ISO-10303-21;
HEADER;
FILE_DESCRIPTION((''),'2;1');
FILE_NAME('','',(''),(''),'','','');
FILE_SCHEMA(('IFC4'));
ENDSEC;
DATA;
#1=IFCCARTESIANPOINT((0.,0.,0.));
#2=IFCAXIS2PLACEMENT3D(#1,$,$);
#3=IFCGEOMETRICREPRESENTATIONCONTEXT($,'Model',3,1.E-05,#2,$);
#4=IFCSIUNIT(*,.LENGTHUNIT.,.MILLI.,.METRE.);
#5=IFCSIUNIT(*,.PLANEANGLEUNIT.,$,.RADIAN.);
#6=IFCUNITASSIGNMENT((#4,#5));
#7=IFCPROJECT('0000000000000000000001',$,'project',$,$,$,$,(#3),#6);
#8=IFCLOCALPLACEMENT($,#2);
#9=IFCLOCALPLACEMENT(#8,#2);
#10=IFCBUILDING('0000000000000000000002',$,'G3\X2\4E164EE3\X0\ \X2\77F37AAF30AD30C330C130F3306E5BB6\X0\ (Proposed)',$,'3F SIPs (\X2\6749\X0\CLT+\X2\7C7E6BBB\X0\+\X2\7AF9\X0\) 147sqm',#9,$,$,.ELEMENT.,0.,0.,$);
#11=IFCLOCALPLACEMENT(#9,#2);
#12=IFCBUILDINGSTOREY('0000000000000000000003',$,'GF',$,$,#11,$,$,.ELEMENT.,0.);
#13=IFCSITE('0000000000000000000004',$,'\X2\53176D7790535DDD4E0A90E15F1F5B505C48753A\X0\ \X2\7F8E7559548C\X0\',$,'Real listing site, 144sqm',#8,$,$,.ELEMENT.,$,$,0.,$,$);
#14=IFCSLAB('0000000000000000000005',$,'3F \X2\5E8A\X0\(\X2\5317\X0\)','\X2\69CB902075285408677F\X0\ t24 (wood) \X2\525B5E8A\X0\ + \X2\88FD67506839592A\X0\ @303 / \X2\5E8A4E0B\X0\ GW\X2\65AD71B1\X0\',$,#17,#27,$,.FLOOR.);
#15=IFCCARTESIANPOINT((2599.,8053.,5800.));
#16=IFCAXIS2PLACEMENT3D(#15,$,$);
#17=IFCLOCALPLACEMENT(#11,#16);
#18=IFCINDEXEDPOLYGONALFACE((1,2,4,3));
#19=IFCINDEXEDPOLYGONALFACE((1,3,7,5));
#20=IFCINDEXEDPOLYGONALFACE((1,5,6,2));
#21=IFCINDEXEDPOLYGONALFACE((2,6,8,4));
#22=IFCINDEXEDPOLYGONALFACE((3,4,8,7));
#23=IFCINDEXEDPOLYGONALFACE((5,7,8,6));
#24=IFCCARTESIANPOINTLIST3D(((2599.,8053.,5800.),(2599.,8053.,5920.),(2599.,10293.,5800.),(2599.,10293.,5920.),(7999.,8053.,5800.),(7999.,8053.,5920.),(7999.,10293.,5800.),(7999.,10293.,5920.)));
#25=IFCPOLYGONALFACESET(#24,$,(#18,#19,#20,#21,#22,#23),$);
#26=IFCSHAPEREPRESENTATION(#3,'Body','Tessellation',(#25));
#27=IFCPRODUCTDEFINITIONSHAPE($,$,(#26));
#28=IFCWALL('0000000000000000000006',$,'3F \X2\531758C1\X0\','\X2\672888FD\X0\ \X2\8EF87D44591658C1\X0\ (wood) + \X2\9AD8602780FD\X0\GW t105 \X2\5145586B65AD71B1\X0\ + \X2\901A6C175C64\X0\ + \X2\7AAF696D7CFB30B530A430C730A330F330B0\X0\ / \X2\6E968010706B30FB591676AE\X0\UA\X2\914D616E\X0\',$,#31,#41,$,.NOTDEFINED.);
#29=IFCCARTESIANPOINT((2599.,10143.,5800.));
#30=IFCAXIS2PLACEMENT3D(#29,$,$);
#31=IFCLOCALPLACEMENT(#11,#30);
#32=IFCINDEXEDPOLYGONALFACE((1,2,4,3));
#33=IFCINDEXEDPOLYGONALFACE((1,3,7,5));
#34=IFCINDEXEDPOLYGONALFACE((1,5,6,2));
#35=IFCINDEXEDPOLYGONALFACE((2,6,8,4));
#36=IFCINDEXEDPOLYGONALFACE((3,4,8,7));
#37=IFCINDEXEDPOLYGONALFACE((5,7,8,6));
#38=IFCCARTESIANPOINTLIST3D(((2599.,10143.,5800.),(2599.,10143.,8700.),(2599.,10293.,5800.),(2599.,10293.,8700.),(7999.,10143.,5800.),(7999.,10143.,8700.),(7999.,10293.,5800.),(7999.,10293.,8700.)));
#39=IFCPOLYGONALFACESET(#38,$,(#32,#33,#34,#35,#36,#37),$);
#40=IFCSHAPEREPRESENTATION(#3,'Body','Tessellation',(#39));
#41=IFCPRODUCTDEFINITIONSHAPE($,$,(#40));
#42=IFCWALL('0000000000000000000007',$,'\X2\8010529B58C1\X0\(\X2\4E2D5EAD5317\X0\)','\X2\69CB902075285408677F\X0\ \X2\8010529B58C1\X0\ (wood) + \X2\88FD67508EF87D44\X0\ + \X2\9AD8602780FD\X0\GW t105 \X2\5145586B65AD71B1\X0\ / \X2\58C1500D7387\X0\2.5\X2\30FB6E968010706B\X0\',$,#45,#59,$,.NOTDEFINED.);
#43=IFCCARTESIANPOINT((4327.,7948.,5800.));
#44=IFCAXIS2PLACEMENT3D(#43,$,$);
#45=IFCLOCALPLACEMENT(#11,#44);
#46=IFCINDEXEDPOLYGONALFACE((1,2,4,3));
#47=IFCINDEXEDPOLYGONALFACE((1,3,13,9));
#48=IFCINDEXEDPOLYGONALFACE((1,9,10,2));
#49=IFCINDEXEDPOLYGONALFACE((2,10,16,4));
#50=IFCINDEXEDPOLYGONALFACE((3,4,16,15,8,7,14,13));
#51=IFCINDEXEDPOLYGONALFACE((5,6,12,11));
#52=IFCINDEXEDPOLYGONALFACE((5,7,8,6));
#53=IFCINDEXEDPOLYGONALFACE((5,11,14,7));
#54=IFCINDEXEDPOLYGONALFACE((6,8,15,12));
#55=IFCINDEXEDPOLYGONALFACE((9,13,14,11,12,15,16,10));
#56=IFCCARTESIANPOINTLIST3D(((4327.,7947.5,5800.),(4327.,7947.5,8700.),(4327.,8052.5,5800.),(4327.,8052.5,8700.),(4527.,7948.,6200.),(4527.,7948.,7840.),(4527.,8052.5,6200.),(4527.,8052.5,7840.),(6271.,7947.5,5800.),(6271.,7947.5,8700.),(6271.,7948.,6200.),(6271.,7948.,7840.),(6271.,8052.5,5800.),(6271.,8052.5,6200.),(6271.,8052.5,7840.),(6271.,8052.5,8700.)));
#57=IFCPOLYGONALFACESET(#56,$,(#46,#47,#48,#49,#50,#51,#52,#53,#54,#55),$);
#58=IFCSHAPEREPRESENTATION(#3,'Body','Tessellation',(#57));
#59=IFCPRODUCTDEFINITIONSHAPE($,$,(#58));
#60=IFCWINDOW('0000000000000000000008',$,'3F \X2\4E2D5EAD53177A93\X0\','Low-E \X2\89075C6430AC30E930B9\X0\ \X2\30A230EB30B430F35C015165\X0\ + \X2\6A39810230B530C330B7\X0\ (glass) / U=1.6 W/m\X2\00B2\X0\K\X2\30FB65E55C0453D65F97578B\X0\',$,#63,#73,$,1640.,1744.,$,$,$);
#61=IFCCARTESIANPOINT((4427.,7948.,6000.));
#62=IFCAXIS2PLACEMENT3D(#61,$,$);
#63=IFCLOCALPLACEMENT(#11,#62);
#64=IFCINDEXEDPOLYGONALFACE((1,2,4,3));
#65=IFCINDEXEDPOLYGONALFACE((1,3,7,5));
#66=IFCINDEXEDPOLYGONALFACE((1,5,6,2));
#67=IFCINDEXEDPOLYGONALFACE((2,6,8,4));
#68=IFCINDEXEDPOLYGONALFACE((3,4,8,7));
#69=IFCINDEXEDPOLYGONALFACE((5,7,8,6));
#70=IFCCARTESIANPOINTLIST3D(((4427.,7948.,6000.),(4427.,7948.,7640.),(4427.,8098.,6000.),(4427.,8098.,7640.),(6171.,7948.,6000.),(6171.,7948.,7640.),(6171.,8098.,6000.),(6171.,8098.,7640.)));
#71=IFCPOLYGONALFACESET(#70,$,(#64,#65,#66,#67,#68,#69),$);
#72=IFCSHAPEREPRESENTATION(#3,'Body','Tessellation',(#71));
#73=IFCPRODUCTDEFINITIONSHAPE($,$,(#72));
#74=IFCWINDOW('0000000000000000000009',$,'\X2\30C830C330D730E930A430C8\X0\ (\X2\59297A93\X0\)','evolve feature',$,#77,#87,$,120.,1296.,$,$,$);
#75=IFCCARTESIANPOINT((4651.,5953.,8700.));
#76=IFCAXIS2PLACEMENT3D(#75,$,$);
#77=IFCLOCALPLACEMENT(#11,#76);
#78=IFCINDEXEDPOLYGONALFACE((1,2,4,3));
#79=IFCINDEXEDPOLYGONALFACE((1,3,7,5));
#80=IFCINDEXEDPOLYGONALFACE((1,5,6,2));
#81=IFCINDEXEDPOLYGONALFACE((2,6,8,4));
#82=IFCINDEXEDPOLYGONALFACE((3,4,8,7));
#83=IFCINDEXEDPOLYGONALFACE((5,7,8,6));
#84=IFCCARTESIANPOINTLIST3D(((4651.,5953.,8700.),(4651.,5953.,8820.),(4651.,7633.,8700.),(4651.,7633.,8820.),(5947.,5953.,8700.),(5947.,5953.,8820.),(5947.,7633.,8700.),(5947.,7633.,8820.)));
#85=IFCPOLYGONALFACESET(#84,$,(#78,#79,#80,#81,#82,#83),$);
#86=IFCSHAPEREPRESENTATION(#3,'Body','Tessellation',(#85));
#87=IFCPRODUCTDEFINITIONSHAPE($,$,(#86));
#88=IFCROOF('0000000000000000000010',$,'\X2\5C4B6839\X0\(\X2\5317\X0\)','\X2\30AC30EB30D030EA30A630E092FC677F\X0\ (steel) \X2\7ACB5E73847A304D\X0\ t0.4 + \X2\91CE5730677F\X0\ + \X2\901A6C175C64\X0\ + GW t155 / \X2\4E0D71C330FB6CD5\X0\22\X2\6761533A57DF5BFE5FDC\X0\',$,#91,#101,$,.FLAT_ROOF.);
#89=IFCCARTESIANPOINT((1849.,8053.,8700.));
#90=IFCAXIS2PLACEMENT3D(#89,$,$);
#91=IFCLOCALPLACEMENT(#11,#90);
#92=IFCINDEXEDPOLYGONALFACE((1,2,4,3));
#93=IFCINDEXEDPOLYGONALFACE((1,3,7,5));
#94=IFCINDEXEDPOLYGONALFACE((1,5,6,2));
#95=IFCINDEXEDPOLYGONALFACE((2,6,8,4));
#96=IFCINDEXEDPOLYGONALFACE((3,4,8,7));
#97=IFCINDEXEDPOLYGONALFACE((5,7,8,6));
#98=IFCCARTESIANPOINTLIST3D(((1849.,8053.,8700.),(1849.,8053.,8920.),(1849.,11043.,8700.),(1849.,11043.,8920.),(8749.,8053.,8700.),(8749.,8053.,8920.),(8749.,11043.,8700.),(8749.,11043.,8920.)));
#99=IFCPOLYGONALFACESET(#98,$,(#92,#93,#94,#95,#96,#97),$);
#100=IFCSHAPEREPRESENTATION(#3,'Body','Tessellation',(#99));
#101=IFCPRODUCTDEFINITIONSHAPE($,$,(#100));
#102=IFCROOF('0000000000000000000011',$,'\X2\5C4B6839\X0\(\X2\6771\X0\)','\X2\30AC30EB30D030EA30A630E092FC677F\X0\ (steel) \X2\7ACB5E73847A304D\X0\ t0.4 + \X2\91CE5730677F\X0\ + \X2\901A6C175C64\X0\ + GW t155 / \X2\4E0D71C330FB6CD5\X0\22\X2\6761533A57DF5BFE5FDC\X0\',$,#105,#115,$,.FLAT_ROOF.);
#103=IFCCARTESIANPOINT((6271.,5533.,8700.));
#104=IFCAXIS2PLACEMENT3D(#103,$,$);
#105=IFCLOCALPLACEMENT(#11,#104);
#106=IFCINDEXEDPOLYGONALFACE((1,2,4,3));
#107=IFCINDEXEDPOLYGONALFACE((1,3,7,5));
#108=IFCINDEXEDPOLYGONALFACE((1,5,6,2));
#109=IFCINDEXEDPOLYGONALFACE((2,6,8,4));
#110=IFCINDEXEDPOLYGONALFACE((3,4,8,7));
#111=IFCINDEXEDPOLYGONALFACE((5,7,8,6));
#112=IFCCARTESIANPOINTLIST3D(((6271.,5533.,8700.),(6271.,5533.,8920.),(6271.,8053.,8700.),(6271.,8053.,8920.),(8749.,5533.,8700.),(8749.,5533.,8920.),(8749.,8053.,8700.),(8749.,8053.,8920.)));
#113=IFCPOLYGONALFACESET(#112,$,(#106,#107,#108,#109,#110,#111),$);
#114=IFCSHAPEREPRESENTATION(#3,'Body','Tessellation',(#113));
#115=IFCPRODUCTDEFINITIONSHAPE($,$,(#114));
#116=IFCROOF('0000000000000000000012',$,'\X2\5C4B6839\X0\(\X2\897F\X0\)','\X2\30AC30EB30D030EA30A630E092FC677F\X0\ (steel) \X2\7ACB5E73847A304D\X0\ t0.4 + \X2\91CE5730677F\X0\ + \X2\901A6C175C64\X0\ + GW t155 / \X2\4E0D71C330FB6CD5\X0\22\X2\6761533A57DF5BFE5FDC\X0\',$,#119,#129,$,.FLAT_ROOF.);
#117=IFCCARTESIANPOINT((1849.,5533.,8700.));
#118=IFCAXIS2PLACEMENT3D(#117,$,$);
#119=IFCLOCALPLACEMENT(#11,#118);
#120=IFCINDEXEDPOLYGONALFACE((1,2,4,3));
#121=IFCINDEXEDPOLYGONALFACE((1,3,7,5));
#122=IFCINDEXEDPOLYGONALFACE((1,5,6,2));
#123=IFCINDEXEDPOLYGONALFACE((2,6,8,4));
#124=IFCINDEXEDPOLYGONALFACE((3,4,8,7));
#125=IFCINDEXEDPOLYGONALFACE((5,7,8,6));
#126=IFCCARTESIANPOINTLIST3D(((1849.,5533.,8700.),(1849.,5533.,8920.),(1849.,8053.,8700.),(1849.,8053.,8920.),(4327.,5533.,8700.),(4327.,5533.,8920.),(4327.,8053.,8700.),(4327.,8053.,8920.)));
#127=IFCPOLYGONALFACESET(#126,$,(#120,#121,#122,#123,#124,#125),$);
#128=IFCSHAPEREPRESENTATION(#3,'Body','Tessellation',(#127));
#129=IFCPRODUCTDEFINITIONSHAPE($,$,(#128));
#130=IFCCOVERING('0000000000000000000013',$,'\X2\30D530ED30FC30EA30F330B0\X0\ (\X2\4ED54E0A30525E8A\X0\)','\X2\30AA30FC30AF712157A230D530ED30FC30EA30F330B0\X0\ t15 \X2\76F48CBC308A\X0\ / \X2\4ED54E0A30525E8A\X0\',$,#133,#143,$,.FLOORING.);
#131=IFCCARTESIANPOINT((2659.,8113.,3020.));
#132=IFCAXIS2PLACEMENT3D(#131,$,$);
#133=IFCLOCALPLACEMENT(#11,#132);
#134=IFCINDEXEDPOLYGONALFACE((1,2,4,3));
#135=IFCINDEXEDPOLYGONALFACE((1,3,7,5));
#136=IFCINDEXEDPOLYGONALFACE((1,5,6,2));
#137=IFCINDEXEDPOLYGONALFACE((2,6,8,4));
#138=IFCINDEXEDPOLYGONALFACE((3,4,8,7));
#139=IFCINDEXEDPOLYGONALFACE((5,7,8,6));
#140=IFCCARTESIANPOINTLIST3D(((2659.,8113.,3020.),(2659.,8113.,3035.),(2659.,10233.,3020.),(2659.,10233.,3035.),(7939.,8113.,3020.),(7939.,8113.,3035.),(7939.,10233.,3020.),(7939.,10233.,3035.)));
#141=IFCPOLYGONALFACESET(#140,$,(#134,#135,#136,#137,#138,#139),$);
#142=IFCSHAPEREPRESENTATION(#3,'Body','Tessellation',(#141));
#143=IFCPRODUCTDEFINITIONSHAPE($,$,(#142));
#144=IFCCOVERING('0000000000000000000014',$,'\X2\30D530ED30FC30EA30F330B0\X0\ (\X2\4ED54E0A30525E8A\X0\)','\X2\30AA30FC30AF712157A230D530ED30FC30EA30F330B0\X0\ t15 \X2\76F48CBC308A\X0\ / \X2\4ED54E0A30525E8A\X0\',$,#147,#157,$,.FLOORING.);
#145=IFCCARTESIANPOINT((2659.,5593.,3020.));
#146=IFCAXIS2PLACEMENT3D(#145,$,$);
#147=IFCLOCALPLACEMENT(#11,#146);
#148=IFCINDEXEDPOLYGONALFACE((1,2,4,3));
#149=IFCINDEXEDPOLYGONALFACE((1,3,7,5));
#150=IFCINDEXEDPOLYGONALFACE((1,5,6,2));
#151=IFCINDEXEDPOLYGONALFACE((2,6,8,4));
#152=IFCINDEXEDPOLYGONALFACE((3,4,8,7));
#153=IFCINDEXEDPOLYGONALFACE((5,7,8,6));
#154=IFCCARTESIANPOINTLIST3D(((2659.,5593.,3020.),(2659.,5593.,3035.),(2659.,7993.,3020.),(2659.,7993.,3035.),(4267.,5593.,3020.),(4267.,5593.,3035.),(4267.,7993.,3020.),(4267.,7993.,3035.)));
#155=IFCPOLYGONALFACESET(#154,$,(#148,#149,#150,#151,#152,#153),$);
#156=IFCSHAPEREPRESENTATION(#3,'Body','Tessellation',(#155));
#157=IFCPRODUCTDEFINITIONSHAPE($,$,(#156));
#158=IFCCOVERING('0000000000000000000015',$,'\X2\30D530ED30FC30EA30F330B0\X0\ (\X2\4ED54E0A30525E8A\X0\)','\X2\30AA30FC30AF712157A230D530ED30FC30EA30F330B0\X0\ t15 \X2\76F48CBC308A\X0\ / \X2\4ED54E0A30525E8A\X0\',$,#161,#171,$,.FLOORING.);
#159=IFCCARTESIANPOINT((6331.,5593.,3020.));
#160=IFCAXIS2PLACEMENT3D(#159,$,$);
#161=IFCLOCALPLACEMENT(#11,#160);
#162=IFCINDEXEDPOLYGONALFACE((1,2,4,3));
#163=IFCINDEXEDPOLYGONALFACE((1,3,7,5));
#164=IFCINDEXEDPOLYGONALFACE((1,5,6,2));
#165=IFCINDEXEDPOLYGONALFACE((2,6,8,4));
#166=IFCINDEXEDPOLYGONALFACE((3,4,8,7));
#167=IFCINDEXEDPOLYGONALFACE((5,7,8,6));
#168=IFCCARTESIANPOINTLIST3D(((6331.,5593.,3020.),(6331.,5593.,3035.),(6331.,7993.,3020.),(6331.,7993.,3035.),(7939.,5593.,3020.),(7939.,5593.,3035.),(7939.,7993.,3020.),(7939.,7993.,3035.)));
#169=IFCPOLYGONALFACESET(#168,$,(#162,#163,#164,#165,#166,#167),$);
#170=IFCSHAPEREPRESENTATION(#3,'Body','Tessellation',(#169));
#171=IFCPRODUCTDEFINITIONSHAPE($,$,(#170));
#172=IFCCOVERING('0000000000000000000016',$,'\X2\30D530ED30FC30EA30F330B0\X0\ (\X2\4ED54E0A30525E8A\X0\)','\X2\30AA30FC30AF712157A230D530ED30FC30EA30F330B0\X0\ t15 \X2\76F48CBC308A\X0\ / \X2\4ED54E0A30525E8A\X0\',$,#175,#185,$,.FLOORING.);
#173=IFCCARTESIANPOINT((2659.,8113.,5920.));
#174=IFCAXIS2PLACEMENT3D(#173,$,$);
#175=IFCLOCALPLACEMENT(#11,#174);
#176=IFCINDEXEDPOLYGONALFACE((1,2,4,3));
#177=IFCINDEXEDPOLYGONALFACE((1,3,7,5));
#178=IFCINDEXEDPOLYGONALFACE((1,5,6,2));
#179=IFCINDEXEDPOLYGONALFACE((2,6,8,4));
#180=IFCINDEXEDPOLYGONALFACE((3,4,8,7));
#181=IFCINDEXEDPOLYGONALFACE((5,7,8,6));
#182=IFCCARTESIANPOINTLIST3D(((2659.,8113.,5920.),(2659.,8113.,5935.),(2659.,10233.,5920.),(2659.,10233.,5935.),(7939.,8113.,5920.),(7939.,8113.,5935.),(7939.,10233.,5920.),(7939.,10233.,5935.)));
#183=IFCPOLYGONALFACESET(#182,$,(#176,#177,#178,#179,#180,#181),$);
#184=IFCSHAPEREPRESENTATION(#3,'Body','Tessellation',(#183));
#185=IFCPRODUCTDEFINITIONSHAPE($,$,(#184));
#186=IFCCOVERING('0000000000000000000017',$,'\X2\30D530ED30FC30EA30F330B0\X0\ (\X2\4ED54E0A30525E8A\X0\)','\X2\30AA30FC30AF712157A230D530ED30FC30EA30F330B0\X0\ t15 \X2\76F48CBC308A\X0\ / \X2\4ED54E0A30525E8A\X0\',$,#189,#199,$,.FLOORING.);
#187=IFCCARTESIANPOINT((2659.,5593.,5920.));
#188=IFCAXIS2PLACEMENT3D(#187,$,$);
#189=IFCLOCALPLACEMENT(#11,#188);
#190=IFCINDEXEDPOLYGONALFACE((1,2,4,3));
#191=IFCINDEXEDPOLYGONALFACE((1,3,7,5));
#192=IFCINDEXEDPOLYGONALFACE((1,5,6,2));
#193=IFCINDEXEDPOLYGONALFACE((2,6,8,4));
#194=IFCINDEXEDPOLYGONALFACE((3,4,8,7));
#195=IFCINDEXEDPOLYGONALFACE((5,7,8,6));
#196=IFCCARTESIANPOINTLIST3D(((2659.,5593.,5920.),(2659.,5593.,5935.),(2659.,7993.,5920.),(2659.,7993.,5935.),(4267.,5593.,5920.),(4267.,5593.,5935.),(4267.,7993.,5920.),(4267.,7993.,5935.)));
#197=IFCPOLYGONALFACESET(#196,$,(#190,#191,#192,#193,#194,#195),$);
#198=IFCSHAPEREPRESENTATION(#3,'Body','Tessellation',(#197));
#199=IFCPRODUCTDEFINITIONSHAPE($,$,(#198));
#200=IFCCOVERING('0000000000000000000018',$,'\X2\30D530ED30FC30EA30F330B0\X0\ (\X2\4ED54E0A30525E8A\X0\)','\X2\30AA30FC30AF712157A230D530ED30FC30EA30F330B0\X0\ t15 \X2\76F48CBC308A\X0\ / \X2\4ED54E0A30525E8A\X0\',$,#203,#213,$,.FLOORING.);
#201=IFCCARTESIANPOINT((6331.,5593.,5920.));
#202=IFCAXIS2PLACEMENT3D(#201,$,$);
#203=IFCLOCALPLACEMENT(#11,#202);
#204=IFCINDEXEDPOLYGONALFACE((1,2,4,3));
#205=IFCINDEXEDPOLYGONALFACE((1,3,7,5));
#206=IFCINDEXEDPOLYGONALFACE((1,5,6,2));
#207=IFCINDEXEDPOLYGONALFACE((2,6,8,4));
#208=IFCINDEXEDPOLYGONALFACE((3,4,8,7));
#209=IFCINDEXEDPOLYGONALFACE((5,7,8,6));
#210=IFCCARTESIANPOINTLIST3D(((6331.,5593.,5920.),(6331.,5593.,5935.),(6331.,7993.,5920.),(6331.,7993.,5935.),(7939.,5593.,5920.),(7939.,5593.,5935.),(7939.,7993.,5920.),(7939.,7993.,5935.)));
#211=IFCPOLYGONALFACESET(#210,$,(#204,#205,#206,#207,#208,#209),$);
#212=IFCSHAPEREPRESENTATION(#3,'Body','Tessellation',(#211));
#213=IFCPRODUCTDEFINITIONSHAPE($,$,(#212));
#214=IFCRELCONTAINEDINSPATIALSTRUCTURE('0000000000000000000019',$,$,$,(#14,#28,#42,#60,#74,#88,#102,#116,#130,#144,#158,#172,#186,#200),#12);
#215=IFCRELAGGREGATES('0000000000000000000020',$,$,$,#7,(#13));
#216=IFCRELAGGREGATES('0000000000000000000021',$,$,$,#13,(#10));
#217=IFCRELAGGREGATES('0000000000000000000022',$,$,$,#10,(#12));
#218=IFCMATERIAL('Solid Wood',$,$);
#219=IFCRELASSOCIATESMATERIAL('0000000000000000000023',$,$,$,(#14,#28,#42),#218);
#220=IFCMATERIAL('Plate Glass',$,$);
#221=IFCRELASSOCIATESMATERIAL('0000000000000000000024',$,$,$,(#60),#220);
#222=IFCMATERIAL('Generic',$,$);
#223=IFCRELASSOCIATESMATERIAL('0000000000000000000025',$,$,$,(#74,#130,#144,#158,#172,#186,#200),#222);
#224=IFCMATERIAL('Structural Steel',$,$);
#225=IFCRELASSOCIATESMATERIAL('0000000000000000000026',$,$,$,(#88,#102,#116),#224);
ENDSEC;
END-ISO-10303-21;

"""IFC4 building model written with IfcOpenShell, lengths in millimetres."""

from ifc_helpers import new_model, si_unit, frame, frame_2d, origin, place, context, project, spatial, rectangle, extrude, material, element, fill, save


model = new_model("IFC4")

# Units and contexts
model_context = context("Model", 3, precision=1e-05, world=origin())
ifc_project = project(units=[si_unit("LENGTHUNIT", "METRE", prefix="MILLI"), si_unit("PLANEANGLEUNIT", "RADIAN")], contexts=[model_context])

# Site, building, storey
site_placement = place(None, origin())
site = spatial("IfcSite", under=ifc_project, at=site_placement, Name="北海道川上郡弟子屈町 美留和", ObjectType="Real listing site, 144sqm", CompositionType="ELEMENT", RefElevation=0.0)
building_placement = place(site_placement, origin())
building = spatial("IfcBuilding", under=site, at=building_placement, Name="G3世代 石窯キッチンの家 (Proposed)", ObjectType="3F SIPs (杉CLT+籾殻+竹) 147sqm", CompositionType="ELEMENT", ElevationOfRefHeight=0.0, ElevationOfTerrain=0.0)
storey_placement = place(building_placement, origin())
storey = spatial("IfcBuildingStorey", under=building, at=storey_placement, Name="GF", CompositionType="ELEMENT", Elevation=0.0)

# Slab
ifc_material_1 = material(Name="Solid Wood")
slab_placement = place(storey_placement, frame((2599.0, 8053.0, 5800.0)))
element("IfcSlab", 1, at=slab_placement, inside=storey, material=ifc_material_1, Name="3F 床(北)", Description="構造用合板 t24 (wood) 剛床 + 製材根太 @303 / 床下 GW断熱", PredefinedType="FLOOR", context=model_context, shape_type="SweptSolid", body=[
    extrude(rectangle(XDim=5400.0, YDim=2240.0, at=frame_2d((2700.0, 1120.0))), frame((2599.0, 8053.0, 5800.0)), (0.0, 0.0, 1.0), 120.0),
])

# Wall
wall_1_placement = place(storey_placement, frame((2599.0, 10143.0, 5800.0)))
element("IfcWall", 2, at=wall_1_placement, inside=storey, material=ifc_material_1, Name="3F 北壁", Description="木製 軸組外壁 (wood) + 高性能GW t105 充填断熱 + 通気層 + 窯業系サイディング / 準耐火・外皮UA配慮", PredefinedType="NOTDEFINED", context=model_context, shape_type="SweptSolid", body=[
    extrude(rectangle(XDim=5400.0, YDim=150.0, at=frame_2d((2700.0, 75.0))), frame((2599.0, 10143.0, 5800.0)), (0.0, 0.0, 1.0), 2900.0),
])

# Wall, opening, window
wall_2_placement = place(storey_placement, frame((4327.0, 7948.0, 5800.0)))
wall_2 = element("IfcWall", 3, at=wall_2_placement, inside=storey, material=ifc_material_1, Name="耐力壁(中庭北)", Description="構造用合板 耐力壁 (wood) + 製材軸組 + 高性能GW t105 充填断熱 / 壁倍率2.5・準耐火", PredefinedType="NOTDEFINED", context=model_context, shape_type="SweptSolid", body=[
    extrude(rectangle(XDim=1944.0, YDim=105.0, at=frame_2d((972.0, 52.0))), frame((4327.0, 7948.0, 5800.0)), (0.0, 0.0, 1.0), 2900.0),
])
opening_placement = place(storey_placement, frame((4427.0, 7948.0, 6000.0)))
opening = element("IfcOpeningElement", 4, at=opening_placement, cuts=wall_2, PredefinedType="NOTDEFINED", context=model_context, shape_type="SweptSolid", body=[
    extrude(rectangle(XDim=1744.0, YDim=150.0, at=frame_2d((872.0, 75.0))), frame((4427.0, 7948.0, 6000.0)), (0.0, 0.0, 1.0), 1640.0),
])
ifc_material_2 = material(Name="Plate Glass")
window_1_placement = place(storey_placement, frame((4427.0, 7948.0, 6000.0)))
window_1 = element("IfcWindow", 5, at=window_1_placement, inside=storey, material=ifc_material_2, Name="3F 中庭北窓", Description="Low-E 複層ガラス アルゴン封入 + 樹脂サッシ (glass) / U=1.6 W/m²K・日射取得型", OverallHeight=1640.0, OverallWidth=1744.0, context=model_context, shape_type="SweptSolid", body=[
    extrude(rectangle(XDim=1744.0, YDim=150.0, at=frame_2d((872.0, 75.0))), frame((4427.0, 7948.0, 6000.0)), (0.0, 0.0, 1.0), 1640.0),
])
fill(opening, window_1)

# Window
ifc_material_3 = material(Name="Generic")
window_2_placement = place(storey_placement, frame((4651.0, 5953.0, 8700.0)))
element("IfcWindow", 6, at=window_2_placement, inside=storey, material=ifc_material_3, Name="トップライト (天窓)", Description="evolve feature", OverallHeight=120.0, OverallWidth=1296.0, context=model_context, shape_type="SweptSolid", body=[
    extrude(rectangle(XDim=1296.0, YDim=1680.0, at=frame_2d((648.0, 840.0))), frame((4651.0, 5953.0, 8700.0)), (0.0, 0.0, 1.0), 120.0),
])

# Roofs
ifc_material_4 = material(Name="Structural Steel")
roof_1_placement = place(storey_placement, frame((1849.0, 8053.0, 8700.0)))
element("IfcRoof", 7, at=roof_1_placement, inside=storey, material=ifc_material_4, Name="屋根(北)", Description="ガルバリウム鋼板 (steel) 立平葺き t0.4 + 野地板 + 通気層 + GW t155 / 不燃・法22条区域対応", PredefinedType="FLAT_ROOF", context=model_context, shape_type="SweptSolid", body=[
    extrude(rectangle(XDim=6900.0, YDim=2990.0, at=frame_2d((3450.0, 1495.0))), frame((1849.0, 8053.0, 8700.0)), (0.0, 0.0, 1.0), 220.0),
])
roof_2_placement = place(storey_placement, frame((6271.0, 5533.0, 8700.0)))
element("IfcRoof", 8, at=roof_2_placement, inside=storey, material=ifc_material_4, Name="屋根(東)", Description="ガルバリウム鋼板 (steel) 立平葺き t0.4 + 野地板 + 通気層 + GW t155 / 不燃・法22条区域対応", PredefinedType="FLAT_ROOF", context=model_context, shape_type="SweptSolid", body=[
    extrude(rectangle(XDim=2478.0, YDim=2520.0, at=frame_2d((1239.0, 1260.0))), frame((6271.0, 5533.0, 8700.0)), (0.0, 0.0, 1.0), 220.0),
])
roof_3_placement = place(storey_placement, frame((1849.0, 5533.0, 8700.0)))
element("IfcRoof", 9, at=roof_3_placement, inside=storey, material=ifc_material_4, Name="屋根(西)", Description="ガルバリウム鋼板 (steel) 立平葺き t0.4 + 野地板 + 通気層 + GW t155 / 不燃・法22条区域対応", PredefinedType="FLAT_ROOF", context=model_context, shape_type="SweptSolid", body=[
    extrude(rectangle(XDim=2478.0, YDim=2520.0, at=frame_2d((1239.0, 1260.0))), frame((1849.0, 5533.0, 8700.0)), (0.0, 0.0, 1.0), 220.0),
])

# Coverings
covering_1_placement = place(storey_placement, frame((2659.0, 8113.0, 3020.0)))
element("IfcCovering", 10, at=covering_1_placement, inside=storey, material=ifc_material_3, Name="フローリング (仕上げ床)", Description="オーク無垢フローリング t15 直貼り / 仕上げ床", PredefinedType="FLOORING", context=model_context, shape_type="SweptSolid", body=[
    extrude(rectangle(XDim=5280.0, YDim=2120.0, at=frame_2d((2640.0, 1060.0))), frame((2659.0, 8113.0, 3020.0)), (0.0, 0.0, 1.0), 15.0),
])
covering_2_placement = place(storey_placement, frame((2659.0, 5593.0, 3020.0)))
element("IfcCovering", 11, at=covering_2_placement, inside=storey, material=ifc_material_3, Name="フローリング (仕上げ床)", Description="オーク無垢フローリング t15 直貼り / 仕上げ床", PredefinedType="FLOORING", context=model_context, shape_type="SweptSolid", body=[
    extrude(rectangle(XDim=1608.0, YDim=2400.0, at=frame_2d((804.0, 1200.0))), frame((2659.0, 5593.0, 3020.0)), (0.0, 0.0, 1.0), 15.0),
])
covering_3_placement = place(storey_placement, frame((6331.0, 5593.0, 3020.0)))
element("IfcCovering", 12, at=covering_3_placement, inside=storey, material=ifc_material_3, Name="フローリング (仕上げ床)", Description="オーク無垢フローリング t15 直貼り / 仕上げ床", PredefinedType="FLOORING", context=model_context, shape_type="SweptSolid", body=[
    extrude(rectangle(XDim=1608.0, YDim=2400.0, at=frame_2d((804.0, 1200.0))), frame((6331.0, 5593.0, 3020.0)), (0.0, 0.0, 1.0), 15.0),
])
covering_4_placement = place(storey_placement, frame((2659.0, 8113.0, 5920.0)))
element("IfcCovering", 13, at=covering_4_placement, inside=storey, material=ifc_material_3, Name="フローリング (仕上げ床)", Description="オーク無垢フローリング t15 直貼り / 仕上げ床", PredefinedType="FLOORING", context=model_context, shape_type="SweptSolid", body=[
    extrude(rectangle(XDim=5280.0, YDim=2120.0, at=frame_2d((2640.0, 1060.0))), frame((2659.0, 8113.0, 5920.0)), (0.0, 0.0, 1.0), 15.0),
])
covering_5_placement = place(storey_placement, frame((2659.0, 5593.0, 5920.0)))
element("IfcCovering", 14, at=covering_5_placement, inside=storey, material=ifc_material_3, Name="フローリング (仕上げ床)", Description="オーク無垢フローリング t15 直貼り / 仕上げ床", PredefinedType="FLOORING", context=model_context, shape_type="SweptSolid", body=[
    extrude(rectangle(XDim=1608.0, YDim=2400.0, at=frame_2d((804.0, 1200.0))), frame((2659.0, 5593.0, 5920.0)), (0.0, 0.0, 1.0), 15.0),
])
covering_6_placement = place(storey_placement, frame((6331.0, 5593.0, 5920.0)))
element("IfcCovering", 15, at=covering_6_placement, inside=storey, material=ifc_material_3, Name="フローリング (仕上げ床)", Description="オーク無垢フローリング t15 直貼り / 仕上げ床", PredefinedType="FLOORING", context=model_context, shape_type="SweptSolid", body=[
    extrude(rectangle(XDim=1608.0, YDim=2400.0, at=frame_2d((804.0, 1200.0))), frame((6331.0, 5593.0, 5920.0)), (0.0, 0.0, 1.0), 15.0),
])

save(model, "model.ifc")
